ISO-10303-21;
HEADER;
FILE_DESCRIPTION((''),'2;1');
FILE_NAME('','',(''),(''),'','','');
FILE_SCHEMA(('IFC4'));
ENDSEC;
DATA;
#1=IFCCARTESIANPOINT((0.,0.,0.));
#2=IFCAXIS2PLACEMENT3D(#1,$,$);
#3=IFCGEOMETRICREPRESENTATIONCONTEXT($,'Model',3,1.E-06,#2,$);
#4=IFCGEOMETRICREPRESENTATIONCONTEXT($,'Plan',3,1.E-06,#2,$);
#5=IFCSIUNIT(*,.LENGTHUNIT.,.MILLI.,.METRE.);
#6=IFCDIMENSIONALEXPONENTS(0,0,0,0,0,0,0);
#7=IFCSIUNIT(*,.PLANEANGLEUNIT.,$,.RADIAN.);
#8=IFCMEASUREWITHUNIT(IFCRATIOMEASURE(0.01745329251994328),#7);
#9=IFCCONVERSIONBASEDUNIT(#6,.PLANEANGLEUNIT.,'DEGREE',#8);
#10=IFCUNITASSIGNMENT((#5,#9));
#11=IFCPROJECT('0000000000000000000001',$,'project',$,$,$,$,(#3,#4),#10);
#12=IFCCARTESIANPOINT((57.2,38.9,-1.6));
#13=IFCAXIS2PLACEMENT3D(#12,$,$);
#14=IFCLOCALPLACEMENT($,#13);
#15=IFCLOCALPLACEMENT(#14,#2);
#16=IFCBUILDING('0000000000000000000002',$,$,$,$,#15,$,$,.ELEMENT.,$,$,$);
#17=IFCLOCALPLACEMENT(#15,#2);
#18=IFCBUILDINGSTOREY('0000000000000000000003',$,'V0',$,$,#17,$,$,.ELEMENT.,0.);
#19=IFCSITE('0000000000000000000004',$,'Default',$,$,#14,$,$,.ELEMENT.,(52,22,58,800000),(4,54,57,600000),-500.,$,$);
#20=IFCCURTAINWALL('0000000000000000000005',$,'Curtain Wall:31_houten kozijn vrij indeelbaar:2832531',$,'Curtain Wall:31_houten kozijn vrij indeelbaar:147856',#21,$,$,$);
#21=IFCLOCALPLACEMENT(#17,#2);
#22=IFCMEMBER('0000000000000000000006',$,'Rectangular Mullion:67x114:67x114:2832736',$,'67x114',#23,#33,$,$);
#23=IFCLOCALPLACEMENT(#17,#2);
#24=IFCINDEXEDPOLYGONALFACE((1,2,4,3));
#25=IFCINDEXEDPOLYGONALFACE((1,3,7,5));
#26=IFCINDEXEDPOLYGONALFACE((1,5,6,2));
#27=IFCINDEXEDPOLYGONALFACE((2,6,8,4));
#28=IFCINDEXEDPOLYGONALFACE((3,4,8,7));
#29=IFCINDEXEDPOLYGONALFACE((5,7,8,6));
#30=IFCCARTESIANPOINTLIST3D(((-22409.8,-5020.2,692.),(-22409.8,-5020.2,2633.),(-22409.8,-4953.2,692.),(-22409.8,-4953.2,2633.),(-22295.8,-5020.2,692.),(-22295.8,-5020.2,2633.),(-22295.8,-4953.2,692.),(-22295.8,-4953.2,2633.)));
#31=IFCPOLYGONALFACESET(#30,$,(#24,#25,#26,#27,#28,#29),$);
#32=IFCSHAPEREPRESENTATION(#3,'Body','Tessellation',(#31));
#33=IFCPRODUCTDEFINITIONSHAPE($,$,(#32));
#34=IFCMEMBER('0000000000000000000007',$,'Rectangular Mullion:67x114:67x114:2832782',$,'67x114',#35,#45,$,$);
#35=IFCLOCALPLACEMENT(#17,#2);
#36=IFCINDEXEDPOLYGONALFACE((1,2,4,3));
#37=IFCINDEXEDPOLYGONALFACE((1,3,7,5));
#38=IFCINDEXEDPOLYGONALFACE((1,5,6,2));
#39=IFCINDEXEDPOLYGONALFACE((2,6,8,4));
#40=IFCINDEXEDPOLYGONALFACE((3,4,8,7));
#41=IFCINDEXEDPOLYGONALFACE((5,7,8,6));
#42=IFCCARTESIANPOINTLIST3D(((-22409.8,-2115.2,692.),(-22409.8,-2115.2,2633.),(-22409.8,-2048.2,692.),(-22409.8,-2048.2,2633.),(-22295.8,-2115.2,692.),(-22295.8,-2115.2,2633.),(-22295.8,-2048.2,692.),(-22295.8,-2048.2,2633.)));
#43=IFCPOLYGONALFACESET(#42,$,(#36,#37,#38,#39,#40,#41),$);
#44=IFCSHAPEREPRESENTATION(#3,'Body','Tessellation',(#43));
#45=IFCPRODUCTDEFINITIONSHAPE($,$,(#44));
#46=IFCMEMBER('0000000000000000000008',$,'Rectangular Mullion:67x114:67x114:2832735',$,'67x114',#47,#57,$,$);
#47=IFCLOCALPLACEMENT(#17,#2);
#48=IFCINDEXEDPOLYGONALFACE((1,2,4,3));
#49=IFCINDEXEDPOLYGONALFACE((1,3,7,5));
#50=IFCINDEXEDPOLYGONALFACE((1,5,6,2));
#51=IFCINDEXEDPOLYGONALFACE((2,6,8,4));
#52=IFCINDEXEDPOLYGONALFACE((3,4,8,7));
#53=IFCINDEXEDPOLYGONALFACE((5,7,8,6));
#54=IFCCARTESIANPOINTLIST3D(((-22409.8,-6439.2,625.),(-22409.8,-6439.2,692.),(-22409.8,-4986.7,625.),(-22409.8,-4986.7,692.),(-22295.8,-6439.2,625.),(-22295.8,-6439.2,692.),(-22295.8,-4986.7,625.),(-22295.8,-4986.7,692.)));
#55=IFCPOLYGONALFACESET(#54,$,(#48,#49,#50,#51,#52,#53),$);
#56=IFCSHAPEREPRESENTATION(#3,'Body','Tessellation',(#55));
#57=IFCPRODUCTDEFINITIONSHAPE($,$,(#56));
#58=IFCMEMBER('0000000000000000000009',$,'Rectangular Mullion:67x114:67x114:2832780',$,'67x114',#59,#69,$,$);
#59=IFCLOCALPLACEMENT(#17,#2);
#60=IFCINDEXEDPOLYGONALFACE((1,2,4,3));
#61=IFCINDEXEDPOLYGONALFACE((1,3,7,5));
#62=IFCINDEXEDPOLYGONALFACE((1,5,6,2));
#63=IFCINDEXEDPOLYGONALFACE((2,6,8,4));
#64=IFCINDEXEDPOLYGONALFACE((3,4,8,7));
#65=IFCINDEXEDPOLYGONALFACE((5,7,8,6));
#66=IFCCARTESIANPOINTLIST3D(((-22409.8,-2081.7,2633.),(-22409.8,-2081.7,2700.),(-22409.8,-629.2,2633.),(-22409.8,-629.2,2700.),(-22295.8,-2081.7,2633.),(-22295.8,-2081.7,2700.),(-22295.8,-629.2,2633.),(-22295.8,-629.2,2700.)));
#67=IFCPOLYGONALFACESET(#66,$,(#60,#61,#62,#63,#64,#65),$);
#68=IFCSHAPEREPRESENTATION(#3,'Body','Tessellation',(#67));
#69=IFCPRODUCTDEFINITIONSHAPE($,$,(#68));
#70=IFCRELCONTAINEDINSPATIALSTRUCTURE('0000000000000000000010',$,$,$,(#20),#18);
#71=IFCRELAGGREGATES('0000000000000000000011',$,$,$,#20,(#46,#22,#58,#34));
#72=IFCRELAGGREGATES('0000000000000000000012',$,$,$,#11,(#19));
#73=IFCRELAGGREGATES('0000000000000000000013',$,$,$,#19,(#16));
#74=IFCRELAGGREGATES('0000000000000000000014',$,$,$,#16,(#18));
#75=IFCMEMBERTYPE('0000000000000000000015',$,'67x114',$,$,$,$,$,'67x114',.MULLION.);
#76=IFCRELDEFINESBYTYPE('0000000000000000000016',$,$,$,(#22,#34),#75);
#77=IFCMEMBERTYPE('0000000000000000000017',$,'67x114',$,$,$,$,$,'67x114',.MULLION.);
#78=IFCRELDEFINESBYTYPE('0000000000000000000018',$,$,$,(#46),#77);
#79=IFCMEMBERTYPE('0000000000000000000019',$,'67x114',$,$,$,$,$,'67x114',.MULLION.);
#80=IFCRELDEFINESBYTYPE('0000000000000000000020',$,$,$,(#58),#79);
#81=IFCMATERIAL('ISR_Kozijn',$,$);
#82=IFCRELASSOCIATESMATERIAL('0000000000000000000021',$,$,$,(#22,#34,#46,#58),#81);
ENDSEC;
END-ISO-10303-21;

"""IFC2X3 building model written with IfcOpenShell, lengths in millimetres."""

from ifc_helpers import new_model, entity, si_unit, converted_unit, frame, origin, origin_2d_with_axis, place, context, project, spatial, rectangle, extrude, source, transform, mapped, material, type_object, type_shapes, element, aggregate, save


model = new_model("IFC2X3")

# Units and contexts
model_context = context("Model", 3, precision=1e-06, world=origin())
plan_context = context("Plan", 3, precision=1e-06, world=origin())
ifc_project = project(units=[si_unit("LENGTHUNIT", "METRE", prefix="MILLI"), converted_unit("PLANEANGLEUNIT", "DEGREE", entity("IfcRatioMeasure", 0.01745329251994328), si_unit("PLANEANGLEUNIT", "RADIAN"), dimensions=[0, 0, 0, 0, 0, 0, 0])], contexts=[model_context, plan_context])

# Site, building, storey
site_placement = place(None, frame((57.2, 38.9, -1.6)))
site = spatial("IfcSite", under=ifc_project, at=site_placement, Name="Default", CompositionType="ELEMENT", RefLatitude=(52, 22, 58, 800000), RefLongitude=(4, 54, 57, 600000), RefElevation=-500.0)
building_placement = place(site_placement, origin())
building = spatial("IfcBuilding", under=site, at=building_placement, CompositionType="ELEMENT")
storey_placement = place(building_placement, origin())
storey = spatial("IfcBuildingStorey", under=building, at=storey_placement, Name="V0", CompositionType="ELEMENT", Elevation=0.0)

# Shared definitions
ifc_material_1 = material(Name="ISR_Kozijn")
placement_1 = place(building_placement, frame((0.0, 0.0, 625.0)))

# Shared definitions
placement_2 = place(building_placement, frame((0.0, 0.0, 2425.0)))

# Curtain wall, members
curtain_wall_1_placement = place(storey_placement, origin())
curtain_wall_1 = element("IfcCurtainWall", 1, at=curtain_wall_1_placement, inside=storey, Name="Curtain Wall:31_houten kozijn vrij indeelbaar:2832531", ObjectType="Curtain Wall:31_houten kozijn vrij indeelbaar:147856")
member_type_1 = type_object("IfcMemberType", Name="67x114", ElementType="67x114", PredefinedType="MULLION")
shared_shape_1 = source(origin(), model_context, "Body", "SweptSolid", [
    extrude(rectangle(XDim=67.0, YDim=114.0, at=origin_2d_with_axis()), frame((0.0, 57.0, -1941.0), z_axis=(0.0, 0.0, 1.0), x_axis=(-1.0, 0.0, 0.0)), (0.0, 0.0, 1.0), 1941.0),
])
type_shapes(member_type_1, [shared_shape_1])
member_1_placement = place(placement_1, frame((-22295.8, -4986.7, 67.0), z_axis=(0.0, 0.0, -1.0), x_axis=(0.0, -1.0, 0.0)))
member_1 = element("IfcMember", 2, at=member_1_placement, type_object=member_type_1, material=ifc_material_1, Name="Rectangular Mullion:67x114:67x114:2832736", ObjectType="67x114", context=model_context, shape_type="MappedRepresentation", body=[
    mapped(shared_shape_1, transform((0.0, 0.0, 0.0), scale=1.0)),
])
member_2_placement = place(placement_1, frame((-22295.8, -2081.7, 67.0), z_axis=(0.0, 0.0, -1.0), x_axis=(0.0, -1.0, 0.0)))
member_2 = element("IfcMember", 3, at=member_2_placement, type_object=member_type_1, material=ifc_material_1, Name="Rectangular Mullion:67x114:67x114:2832782", ObjectType="67x114", context=model_context, shape_type="MappedRepresentation", body=[
    mapped(shared_shape_1, transform((0.0, 0.0, 0.0), scale=1.0)),
])
member_type_2 = type_object("IfcMemberType", Name="67x114", ElementType="67x114", PredefinedType="MULLION")
shared_shape_2 = source(origin(), model_context, "Body", "SweptSolid", [
    extrude(rectangle(XDim=67.0, YDim=114.0, at=origin_2d_with_axis()), frame((-33.5, 57.0, -1452.5), z_axis=(0.0, 0.0, 1.0), x_axis=(-1.0, 0.0, 0.0)), (0.0, 0.0, 1.0), 1452.5),
])
type_shapes(member_type_2, [shared_shape_2])
member_3_placement = place(placement_1, frame((-22295.8, -4986.7, 0.0), z_axis=(0.0, 1.0, 0.0), x_axis=(0.0, 0.0, -1.0)))
member_3 = element("IfcMember", 4, at=member_3_placement, type_object=member_type_2, material=ifc_material_1, Name="Rectangular Mullion:67x114:67x114:2832735", ObjectType="67x114", context=model_context, shape_type="MappedRepresentation", body=[
    mapped(shared_shape_2, transform((0.0, 0.0, 0.0), scale=1.0)),
])
member_type_3 = type_object("IfcMemberType", Name="67x114", ElementType="67x114", PredefinedType="MULLION")
shared_shape_3 = source(origin(), model_context, "Body", "SweptSolid", [
    extrude(rectangle(XDim=67.0, YDim=114.0, at=origin_2d_with_axis()), frame((-33.5, 57.0, -1452.5), z_axis=(0.0, 0.0, 1.0), x_axis=(-1.0, 0.0, 0.0)), (0.0, 0.0, 1.0), 1452.5),
])
type_shapes(member_type_3, [shared_shape_3])
member_4_placement = place(placement_2, frame((-22295.8, -2081.7, 275.0), z_axis=(0.0, -1.0, 0.0), x_axis=(0.0, 0.0, 1.0)))
member_4 = element("IfcMember", 5, at=member_4_placement, type_object=member_type_3, material=ifc_material_1, Name="Rectangular Mullion:67x114:67x114:2832780", ObjectType="67x114", context=model_context, shape_type="MappedRepresentation", body=[
    mapped(shared_shape_3, transform((0.0, 0.0, 0.0), scale=1.0)),
])

aggregate(curtain_wall_1, [member_3, member_1, member_4, member_2])

save(model, "model.ifc")
